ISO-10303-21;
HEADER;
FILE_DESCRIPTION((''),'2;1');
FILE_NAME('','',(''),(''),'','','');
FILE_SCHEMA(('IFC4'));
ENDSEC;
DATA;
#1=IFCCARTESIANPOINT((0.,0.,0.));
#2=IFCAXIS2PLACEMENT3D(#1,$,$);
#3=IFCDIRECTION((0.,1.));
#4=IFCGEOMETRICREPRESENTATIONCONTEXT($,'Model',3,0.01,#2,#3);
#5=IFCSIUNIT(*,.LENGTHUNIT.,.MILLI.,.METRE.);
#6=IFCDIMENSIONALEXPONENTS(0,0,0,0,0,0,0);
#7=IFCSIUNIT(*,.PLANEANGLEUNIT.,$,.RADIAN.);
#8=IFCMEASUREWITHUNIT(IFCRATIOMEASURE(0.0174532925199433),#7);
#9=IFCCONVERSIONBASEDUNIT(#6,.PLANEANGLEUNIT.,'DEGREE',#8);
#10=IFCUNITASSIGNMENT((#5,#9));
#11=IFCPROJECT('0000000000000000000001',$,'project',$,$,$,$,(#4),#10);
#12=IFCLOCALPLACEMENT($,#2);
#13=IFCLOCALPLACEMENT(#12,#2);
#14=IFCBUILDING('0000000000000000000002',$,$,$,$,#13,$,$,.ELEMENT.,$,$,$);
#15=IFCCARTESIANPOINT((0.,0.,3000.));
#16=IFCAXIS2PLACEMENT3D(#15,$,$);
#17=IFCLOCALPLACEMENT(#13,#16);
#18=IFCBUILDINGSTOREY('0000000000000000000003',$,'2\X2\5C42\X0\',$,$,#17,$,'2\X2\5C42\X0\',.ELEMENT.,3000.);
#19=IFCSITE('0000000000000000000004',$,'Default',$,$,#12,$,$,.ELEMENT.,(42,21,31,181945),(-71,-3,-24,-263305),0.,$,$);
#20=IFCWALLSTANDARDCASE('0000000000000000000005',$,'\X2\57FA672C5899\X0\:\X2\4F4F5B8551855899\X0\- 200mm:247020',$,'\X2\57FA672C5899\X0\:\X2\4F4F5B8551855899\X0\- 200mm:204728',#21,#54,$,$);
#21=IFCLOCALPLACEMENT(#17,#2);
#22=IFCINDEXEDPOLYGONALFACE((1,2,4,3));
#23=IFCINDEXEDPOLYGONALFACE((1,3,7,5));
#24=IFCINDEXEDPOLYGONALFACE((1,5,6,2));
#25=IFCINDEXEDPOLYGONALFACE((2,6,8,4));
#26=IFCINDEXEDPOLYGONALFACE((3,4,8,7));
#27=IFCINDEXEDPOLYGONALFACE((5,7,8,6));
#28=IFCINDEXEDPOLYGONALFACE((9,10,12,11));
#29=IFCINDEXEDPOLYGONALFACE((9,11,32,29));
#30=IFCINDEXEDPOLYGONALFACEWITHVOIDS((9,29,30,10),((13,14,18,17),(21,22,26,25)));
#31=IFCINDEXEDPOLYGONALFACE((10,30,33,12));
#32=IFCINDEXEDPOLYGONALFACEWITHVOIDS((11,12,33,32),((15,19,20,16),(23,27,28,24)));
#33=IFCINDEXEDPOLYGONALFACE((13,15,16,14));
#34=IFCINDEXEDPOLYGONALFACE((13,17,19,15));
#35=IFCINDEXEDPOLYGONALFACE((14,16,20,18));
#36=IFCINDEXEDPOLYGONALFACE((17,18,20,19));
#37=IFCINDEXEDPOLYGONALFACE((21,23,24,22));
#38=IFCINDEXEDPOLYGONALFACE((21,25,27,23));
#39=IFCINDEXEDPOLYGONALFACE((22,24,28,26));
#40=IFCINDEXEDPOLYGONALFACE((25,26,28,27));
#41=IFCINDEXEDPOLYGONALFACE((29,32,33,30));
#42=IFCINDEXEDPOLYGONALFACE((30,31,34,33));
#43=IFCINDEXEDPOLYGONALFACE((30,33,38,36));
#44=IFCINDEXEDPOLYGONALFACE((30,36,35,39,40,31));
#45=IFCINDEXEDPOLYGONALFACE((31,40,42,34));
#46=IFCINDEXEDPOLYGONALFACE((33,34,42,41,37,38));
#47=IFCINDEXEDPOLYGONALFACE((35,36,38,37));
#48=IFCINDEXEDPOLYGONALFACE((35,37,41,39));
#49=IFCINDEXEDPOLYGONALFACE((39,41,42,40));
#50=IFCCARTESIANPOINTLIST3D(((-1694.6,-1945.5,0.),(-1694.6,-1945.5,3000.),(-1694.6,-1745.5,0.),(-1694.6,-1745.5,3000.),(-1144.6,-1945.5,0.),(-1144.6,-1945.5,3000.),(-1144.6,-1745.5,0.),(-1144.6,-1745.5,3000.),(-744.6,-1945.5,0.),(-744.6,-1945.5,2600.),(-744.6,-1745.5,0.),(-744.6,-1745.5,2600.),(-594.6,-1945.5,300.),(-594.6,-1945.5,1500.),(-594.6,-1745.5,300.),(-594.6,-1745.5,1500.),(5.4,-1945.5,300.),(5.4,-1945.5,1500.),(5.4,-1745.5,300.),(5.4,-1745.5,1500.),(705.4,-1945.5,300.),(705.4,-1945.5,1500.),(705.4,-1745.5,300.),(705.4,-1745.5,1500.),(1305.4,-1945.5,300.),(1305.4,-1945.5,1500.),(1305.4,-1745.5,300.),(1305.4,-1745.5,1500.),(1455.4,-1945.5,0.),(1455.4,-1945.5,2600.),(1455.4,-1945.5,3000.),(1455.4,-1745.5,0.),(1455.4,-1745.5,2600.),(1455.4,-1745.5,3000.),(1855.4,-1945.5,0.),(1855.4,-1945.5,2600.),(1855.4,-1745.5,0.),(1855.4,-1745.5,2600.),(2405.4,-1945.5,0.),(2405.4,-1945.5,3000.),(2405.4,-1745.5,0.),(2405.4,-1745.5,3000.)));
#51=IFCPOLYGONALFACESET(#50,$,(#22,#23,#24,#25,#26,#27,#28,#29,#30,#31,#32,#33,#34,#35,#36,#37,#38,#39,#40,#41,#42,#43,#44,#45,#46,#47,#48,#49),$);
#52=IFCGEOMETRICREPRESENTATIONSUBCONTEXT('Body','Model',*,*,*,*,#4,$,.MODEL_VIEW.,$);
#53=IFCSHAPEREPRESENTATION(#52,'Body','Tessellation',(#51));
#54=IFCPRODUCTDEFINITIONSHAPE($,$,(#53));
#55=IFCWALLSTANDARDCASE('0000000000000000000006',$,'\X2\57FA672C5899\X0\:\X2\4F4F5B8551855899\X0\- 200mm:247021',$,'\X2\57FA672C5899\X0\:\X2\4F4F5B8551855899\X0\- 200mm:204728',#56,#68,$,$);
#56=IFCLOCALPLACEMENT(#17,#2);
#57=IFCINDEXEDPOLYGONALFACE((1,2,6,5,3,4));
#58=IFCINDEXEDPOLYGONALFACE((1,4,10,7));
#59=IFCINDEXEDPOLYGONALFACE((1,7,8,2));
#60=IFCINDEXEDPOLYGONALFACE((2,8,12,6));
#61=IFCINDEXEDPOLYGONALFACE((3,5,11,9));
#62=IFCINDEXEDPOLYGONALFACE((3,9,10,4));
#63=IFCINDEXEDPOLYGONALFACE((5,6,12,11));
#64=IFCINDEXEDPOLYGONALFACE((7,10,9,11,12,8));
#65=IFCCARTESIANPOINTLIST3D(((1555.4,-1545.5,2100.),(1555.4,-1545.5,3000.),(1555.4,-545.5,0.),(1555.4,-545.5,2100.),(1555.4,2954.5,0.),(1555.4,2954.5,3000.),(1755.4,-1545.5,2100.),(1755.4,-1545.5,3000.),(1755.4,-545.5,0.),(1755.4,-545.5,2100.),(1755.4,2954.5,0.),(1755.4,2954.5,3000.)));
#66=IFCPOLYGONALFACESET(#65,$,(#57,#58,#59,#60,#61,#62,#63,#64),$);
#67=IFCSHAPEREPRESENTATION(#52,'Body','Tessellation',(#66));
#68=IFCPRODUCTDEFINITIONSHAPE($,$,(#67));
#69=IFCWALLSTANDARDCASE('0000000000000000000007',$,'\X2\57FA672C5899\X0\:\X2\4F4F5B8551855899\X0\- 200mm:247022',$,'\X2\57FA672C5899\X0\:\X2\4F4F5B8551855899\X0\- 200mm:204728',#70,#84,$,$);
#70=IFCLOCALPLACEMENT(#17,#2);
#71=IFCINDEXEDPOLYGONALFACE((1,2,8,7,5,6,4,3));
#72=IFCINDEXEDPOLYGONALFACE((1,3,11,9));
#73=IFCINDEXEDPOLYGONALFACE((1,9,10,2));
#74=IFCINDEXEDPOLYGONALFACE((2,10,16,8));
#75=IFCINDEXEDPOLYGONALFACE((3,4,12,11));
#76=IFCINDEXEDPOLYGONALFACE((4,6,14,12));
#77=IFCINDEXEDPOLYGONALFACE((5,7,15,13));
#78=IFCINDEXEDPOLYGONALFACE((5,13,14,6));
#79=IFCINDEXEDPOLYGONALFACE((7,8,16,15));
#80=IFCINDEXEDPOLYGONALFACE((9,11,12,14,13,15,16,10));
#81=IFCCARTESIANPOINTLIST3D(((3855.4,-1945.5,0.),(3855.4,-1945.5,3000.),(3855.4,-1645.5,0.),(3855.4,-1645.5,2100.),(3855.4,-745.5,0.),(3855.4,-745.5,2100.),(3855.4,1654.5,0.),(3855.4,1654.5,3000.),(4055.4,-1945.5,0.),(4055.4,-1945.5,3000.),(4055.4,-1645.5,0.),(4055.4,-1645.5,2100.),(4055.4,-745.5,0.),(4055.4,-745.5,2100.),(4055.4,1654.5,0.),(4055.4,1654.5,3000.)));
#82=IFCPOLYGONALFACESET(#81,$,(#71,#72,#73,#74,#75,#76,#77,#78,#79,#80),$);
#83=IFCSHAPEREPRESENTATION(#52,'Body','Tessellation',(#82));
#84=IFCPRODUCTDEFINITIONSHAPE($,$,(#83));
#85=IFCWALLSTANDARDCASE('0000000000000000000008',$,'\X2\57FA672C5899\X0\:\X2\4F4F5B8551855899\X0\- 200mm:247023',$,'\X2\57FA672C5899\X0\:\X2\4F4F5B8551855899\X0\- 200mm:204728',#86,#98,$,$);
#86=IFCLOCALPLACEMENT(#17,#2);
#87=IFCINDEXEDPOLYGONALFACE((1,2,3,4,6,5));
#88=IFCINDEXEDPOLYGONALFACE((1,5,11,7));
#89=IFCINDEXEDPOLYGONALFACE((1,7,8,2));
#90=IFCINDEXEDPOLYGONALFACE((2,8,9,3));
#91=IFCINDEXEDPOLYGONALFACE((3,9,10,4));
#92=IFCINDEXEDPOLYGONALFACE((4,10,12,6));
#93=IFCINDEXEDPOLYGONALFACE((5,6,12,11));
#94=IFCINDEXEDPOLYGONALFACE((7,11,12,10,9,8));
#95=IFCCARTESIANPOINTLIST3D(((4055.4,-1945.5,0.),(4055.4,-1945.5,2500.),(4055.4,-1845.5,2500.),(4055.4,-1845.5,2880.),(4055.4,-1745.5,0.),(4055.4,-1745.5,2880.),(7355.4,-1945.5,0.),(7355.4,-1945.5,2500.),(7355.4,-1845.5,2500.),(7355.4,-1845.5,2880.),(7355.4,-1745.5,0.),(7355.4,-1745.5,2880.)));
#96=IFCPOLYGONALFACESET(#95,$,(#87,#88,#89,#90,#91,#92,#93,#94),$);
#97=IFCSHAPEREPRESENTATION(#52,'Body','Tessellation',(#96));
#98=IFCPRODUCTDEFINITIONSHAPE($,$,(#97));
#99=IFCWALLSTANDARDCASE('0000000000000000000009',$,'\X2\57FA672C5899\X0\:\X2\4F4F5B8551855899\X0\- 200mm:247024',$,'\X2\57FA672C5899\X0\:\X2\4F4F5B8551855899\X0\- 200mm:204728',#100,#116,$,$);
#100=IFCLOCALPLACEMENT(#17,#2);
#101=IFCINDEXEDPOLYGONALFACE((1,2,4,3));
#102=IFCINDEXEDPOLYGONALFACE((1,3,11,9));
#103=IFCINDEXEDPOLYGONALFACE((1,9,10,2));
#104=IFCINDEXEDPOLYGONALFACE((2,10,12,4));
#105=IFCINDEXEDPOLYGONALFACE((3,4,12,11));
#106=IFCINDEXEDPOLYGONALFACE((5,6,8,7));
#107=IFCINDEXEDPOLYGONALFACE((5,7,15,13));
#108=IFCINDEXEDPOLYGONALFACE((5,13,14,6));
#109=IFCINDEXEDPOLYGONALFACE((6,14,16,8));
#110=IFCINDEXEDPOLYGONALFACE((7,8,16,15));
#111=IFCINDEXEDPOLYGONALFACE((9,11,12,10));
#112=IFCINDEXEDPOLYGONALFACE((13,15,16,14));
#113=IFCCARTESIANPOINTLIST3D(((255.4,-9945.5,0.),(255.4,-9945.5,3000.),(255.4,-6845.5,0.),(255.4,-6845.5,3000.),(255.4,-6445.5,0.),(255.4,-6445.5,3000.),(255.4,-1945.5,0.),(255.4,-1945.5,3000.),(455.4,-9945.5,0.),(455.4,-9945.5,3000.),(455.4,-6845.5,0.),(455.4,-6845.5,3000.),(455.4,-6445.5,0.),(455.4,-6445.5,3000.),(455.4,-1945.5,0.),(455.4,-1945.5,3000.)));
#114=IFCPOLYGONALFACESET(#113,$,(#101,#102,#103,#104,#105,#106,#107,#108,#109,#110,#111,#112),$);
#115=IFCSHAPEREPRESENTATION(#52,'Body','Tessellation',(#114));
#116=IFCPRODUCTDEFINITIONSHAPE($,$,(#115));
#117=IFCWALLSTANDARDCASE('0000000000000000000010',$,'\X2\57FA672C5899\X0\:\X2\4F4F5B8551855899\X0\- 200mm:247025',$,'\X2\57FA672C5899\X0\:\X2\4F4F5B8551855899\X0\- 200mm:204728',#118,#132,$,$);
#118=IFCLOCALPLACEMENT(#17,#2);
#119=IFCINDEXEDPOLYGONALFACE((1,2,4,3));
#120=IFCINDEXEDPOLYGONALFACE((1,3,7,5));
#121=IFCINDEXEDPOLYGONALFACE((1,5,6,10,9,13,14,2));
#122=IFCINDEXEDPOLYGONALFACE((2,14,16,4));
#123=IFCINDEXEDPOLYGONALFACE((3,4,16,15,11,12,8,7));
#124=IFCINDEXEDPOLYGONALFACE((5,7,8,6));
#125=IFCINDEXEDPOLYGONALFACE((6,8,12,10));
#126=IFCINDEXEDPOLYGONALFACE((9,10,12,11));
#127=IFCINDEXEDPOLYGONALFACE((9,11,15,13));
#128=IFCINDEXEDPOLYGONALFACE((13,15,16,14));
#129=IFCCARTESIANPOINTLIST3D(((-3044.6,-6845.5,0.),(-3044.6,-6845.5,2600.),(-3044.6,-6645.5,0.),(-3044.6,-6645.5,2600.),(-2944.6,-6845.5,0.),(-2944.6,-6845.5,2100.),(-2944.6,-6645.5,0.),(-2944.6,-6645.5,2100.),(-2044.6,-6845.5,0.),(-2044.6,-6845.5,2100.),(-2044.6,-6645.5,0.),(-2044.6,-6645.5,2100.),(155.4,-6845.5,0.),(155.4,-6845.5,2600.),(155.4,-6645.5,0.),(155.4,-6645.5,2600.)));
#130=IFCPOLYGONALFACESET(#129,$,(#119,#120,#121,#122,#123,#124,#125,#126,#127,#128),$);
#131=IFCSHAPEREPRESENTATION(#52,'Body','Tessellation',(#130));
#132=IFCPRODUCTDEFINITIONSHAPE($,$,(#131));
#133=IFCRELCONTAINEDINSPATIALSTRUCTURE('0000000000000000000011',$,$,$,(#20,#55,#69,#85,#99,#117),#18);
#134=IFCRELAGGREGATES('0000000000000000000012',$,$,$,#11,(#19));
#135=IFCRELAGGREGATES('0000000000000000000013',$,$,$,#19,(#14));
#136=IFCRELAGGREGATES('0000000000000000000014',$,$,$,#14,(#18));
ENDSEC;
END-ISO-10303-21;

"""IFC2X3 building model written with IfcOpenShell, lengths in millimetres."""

from ifc_helpers import new_model, entity, si_unit, converted_unit, direction, frame, frame_2d, origin, place, context, subcontext, project, spatial, polyline, rectangle, extrude, clip, bounded_halfspace, element, save


model = new_model("IFC2X3")

# Units and contexts
model_context = context("Model", 3, precision=0.01, world=origin(), true_north=direction((0.0, 1.0)))
body_context = subcontext(model_context, "Body", "Model", "MODEL_VIEW")
ifc_project = project(units=[si_unit("LENGTHUNIT", "METRE", prefix="MILLI"), converted_unit("PLANEANGLEUNIT", "DEGREE", entity("IfcRatioMeasure", 0.0174532925199433), si_unit("PLANEANGLEUNIT", "RADIAN"), dimensions=[0, 0, 0, 0, 0, 0, 0])], contexts=[model_context])

# Site, building, storey
site_placement = place(None, origin())
site = spatial("IfcSite", under=ifc_project, at=site_placement, Name="Default", CompositionType="ELEMENT", RefLatitude=(42, 21, 31, 181945), RefLongitude=(-71, -3, -24, -263305), RefElevation=0.0)
building_placement = place(site_placement, origin())
building = spatial("IfcBuilding", under=site, at=building_placement, CompositionType="ELEMENT")
storey_placement = place(building_placement, frame((0.0, 0.0, 3000.0)))
storey = spatial("IfcBuildingStorey", under=building, at=storey_placement, Name="2层", LongName="2层", CompositionType="ELEMENT", Elevation=3000.0)

# Wall, openings
wall_1_placement = place(storey_placement, frame((-1694.6, -1845.5, 0.0)))
wall_1 = element("IfcWallStandardCase", 1, at=wall_1_placement, inside=storey, Name="基本墙:住宅内墙- 200mm:247020", ObjectType="基本墙:住宅内墙- 200mm:204728", context=body_context, shape_type="Clipping", body=[
    clip(extrude(rectangle(XDim=4100.0, YDim=200.0, at=frame_2d((2050.0, 0.0), x_axis=(-1.0, 0.0))), origin(), (0.0, 0.0, 1.0), 3000.0), bounded_halfspace(frame((950.0, -100.0, 2600.0), z_axis=(0.0, 0.0, -1.0), x_axis=(-1.0, 0.0, 0.0)), True, frame((950.0, -100.0, 2600.0), z_axis=(0.0, 0.0, -1.0), x_axis=(-1.0, 0.0, 0.0)), polyline([(0.0, 0.0), (0.0, 200.0), (-2200.0, 200.0), (-2200.0, 0.0), (0.0, 0.0)]))),
])
opening_1_placement = place(wall_1_placement, frame((3000.0, 100.0, 300.0)))
element("IfcOpeningElement", 2, at=opening_1_placement, cuts=wall_1, ObjectType="Opening", context=body_context, shape_type="SweptSolid", body=[
    extrude(rectangle(XDim=1200.0, YDim=600.0, at=frame_2d((600.0, 300.0), x_axis=(-1.0, 0.0))), frame((0.0, 0.0, 0.0), z_axis=(0.0, -1.0, 0.0), x_axis=(0.0, 0.0, 1.0)), (0.0, 0.0, 1.0), 200.0),
])
opening_2_placement = place(wall_1_placement, frame((1700.0, 100.0, 300.0)))
element("IfcOpeningElement", 3, at=opening_2_placement, cuts=wall_1, ObjectType="Opening", context=body_context, shape_type="SweptSolid", body=[
    extrude(rectangle(XDim=1200.0, YDim=600.0, at=frame_2d((600.0, 300.0), x_axis=(-1.0, 0.0))), frame((0.0, 0.0, 0.0), z_axis=(0.0, -1.0, 0.0), x_axis=(0.0, 0.0, 1.0)), (0.0, 0.0, 1.0), 200.0),
])
opening_3_placement = place(storey_placement, frame((-1694.6, -1845.5, 0.0)))
element("IfcOpeningElement", 4, at=opening_3_placement, cuts=wall_1, ObjectType="Opening", context=body_context, shape_type="SweptSolid", body=[
    extrude(rectangle(XDim=2600.0, YDim=200.0, at=frame_2d((0.0, 0.0), x_axis=(0.0, 1.0))), frame((3150.0, 0.0, 1300.0), z_axis=(1.0, 0.0, 0.0), x_axis=(0.0, 1.0, 0.0)), (0.0, 0.0, 1.0), 400.0),
])
opening_4_placement = place(storey_placement, frame((-1694.6, -1845.5, 0.0)))
element("IfcOpeningElement", 5, at=opening_4_placement, cuts=wall_1, ObjectType="Opening", context=body_context, shape_type="SweptSolid", body=[
    extrude(rectangle(XDim=3000.0, YDim=200.0, at=frame_2d((0.0, 0.0), x_axis=(1.0, 0.0))), frame((550.0, 0.0, 1500.0), z_axis=(1.0, 0.0, 0.0), x_axis=(0.0, 0.0, -1.0)), (0.0, 0.0, 1.0), 400.0),
])

# Walls, openings
wall_2_placement = place(storey_placement, frame((1655.4, -1545.5, 0.0), z_axis=(0.0, 0.0, 1.0), x_axis=(0.0, 1.0, 0.0)))
wall_2 = element("IfcWallStandardCase", 6, at=wall_2_placement, inside=storey, Name="基本墙:住宅内墙- 200mm:247021", ObjectType="基本墙:住宅内墙- 200mm:204728", context=body_context, shape_type="Clipping", body=[
    clip(clip(extrude(rectangle(XDim=4500.0, YDim=200.0, at=frame_2d((2250.0, 0.0), x_axis=(-1.0, 0.0))), origin(), (0.0, 0.0, 1.0), 3000.0), bounded_halfspace(frame((0.0, -100.0, 2100.0), z_axis=(-1.0, 0.0, 0.0), x_axis=(0.0, 0.0, -1.0)), False, frame((0.0, -100.0, 2100.0), z_axis=(-1.0, 0.0, 0.0), x_axis=(0.0, 0.0, -1.0)), polyline([(0.0, 0.0), (-900.0, 0.0), (-900.0, -200.0), (0.0, -200.0), (0.0, 0.0)]))), bounded_halfspace(frame((4500.0, -100.0, 3000.0), z_axis=(1.0, 0.0, 0.0), x_axis=(0.0, 0.0, -1.0)), False, frame((4500.0, -100.0, 3000.0), z_axis=(1.0, 0.0, 0.0), x_axis=(0.0, 0.0, -1.0)), polyline([(0.0, 0.0), (3000.0, 0.0), (3000.0, 200.0), (0.0, 200.0), (0.0, 0.0)]))),
])
opening_5_placement = place(wall_2_placement, frame((0.0, -100.0, 0.0)))
element("IfcOpeningElement", 7, at=opening_5_placement, cuts=wall_2, ObjectType="Opening", context=body_context, shape_type="SweptSolid", body=[
    extrude(rectangle(XDim=2100.0, YDim=1000.0, at=frame_2d((1050.0, 500.0), x_axis=(1.0, 0.0))), frame((0.0, 0.0, 0.0), z_axis=(0.0, 1.0, 0.0), x_axis=(0.0, 0.0, 1.0)), (0.0, 0.0, 1.0), 200.0),
])
wall_3_placement = place(storey_placement, frame((3955.4, 1654.5, 0.0), z_axis=(0.0, 0.0, 1.0), x_axis=(0.0, -1.0, 0.0)))
wall_3 = element("IfcWallStandardCase", 8, at=wall_3_placement, inside=storey, Name="基本墙:住宅内墙- 200mm:247022", ObjectType="基本墙:住宅内墙- 200mm:204728", context=body_context, shape_type="SweptSolid", body=[
    extrude(rectangle(XDim=3600.0, YDim=200.0, at=frame_2d((1800.0, 0.0), x_axis=(-1.0, 0.0))), origin(), (0.0, 0.0, 1.0), 3000.0),
])
opening_6_placement = place(wall_3_placement, frame((2400.0, -100.0, 0.0)))
element("IfcOpeningElement", 9, at=opening_6_placement, cuts=wall_3, ObjectType="Opening", context=body_context, shape_type="SweptSolid", body=[
    extrude(rectangle(XDim=2100.0, YDim=900.0, at=frame_2d((1050.0, 450.0), x_axis=(1.0, 0.0))), frame((0.0, 0.0, 0.0), z_axis=(0.0, 1.0, 0.0), x_axis=(0.0, 0.0, 1.0)), (0.0, 0.0, 1.0), 200.0),
])

# Wall
wall_4_placement = place(storey_placement, frame((4055.4, -1845.5, 0.0)))
element("IfcWallStandardCase", 10, at=wall_4_placement, inside=storey, Name="基本墙:住宅内墙- 200mm:247023", ObjectType="基本墙:住宅内墙- 200mm:204728", context=body_context, shape_type="Clipping", body=[
    clip(clip(clip(clip(extrude(rectangle(XDim=3300.0, YDim=200.0, at=frame_2d((1650.0, 0.0), x_axis=(-1.0, 0.0))), origin(), (0.0, 0.0, 1.0), 2880.0), bounded_halfspace(frame((3300.0, -100.0, 0.0), z_axis=(1.0, 0.0, 0.0), x_axis=(0.0, 0.0, -1.0)), False, frame((3300.0, -100.0, 0.0), z_axis=(1.0, 0.0, 0.0), x_axis=(0.0, 0.0, -1.0)), polyline([(0.0, 0.0), (0.0, 200.0), (-2880.0, 200.0), (-2880.0, 100.0), (-2500.0, 100.0), (-2500.0, 0.0), (0.0, 0.0)]))), bounded_halfspace(frame((3300.0, 100.0, 2880.0), z_axis=(0.0, 0.0, -1.0), x_axis=(1.0, 0.0, 0.0)), True, frame((3300.0, 100.0, 2880.0), z_axis=(0.0, 0.0, -1.0), x_axis=(1.0, 0.0, 0.0)), polyline([(0.0, 0.0), (0.0, 100.0), (-3300.0, 100.0), (-3300.0, 0.0), (0.0, 0.0)]))), bounded_halfspace(frame((3300.0, 0.0, 2500.0)), False, frame((3300.0, 0.0, 2500.0)), polyline([(0.0, 0.0), (-3300.0, 0.0), (-3300.0, -100.0), (0.0, -100.0), (0.0, 0.0)]))), bounded_halfspace(frame((0.0, 0.0, 2500.0), z_axis=(0.0, -1.0, 0.0), x_axis=(1.0, 0.0, 0.0)), False, frame((0.0, 0.0, 2500.0), z_axis=(0.0, -1.0, 0.0), x_axis=(1.0, 0.0, 0.0)), polyline([(0.0, 0.0), (3300.0, 0.0), (3300.0, 380.0), (0.0, 380.0), (0.0, 0.0)]))),
])

# Walls, openings
wall_5_placement = place(storey_placement, frame((355.4, -1945.5, 0.0), z_axis=(0.0, 0.0, 1.0), x_axis=(0.0, -1.0, 0.0)))
wall_5 = element("IfcWallStandardCase", 11, at=wall_5_placement, inside=storey, Name="基本墙:住宅内墙- 200mm:247024", ObjectType="基本墙:住宅内墙- 200mm:204728", context=body_context, shape_type="Clipping", body=[
    clip(extrude(rectangle(XDim=8000.0, YDim=200.0, at=frame_2d((4000.0, 0.0), x_axis=(-1.0, 0.0))), origin(), (0.0, 0.0, 1.0), 3000.0), bounded_halfspace(frame((8000.0, -100.0, 3000.0), z_axis=(-1.0, 0.0, 0.0), x_axis=(0.0, 0.0, -1.0)), True, frame((8000.0, -100.0, 3000.0), z_axis=(-1.0, 0.0, 0.0), x_axis=(0.0, 0.0, -1.0)), polyline([(0.0, 0.0), (0.0, -200.0), (3000.0, -200.0), (3000.0, 0.0), (0.0, 0.0)]))),
])
opening_7_placement = place(storey_placement, frame((355.4, -1945.5, 0.0), z_axis=(0.0, 0.0, 1.0), x_axis=(0.0, -1.0, 0.0)))
element("IfcOpeningElement", 12, at=opening_7_placement, cuts=wall_5, ObjectType="Opening", context=body_context, shape_type="SweptSolid", body=[
    extrude(rectangle(XDim=3000.0, YDim=200.0, at=frame_2d((0.0, 0.0), x_axis=(1.0, 0.0))), frame((4900.0, 0.0, 1500.0), z_axis=(-1.0, 0.0, 0.0), x_axis=(0.0, 0.0, 1.0)), (0.0, 0.0, 1.0), 400.0),
])
wall_6_placement = place(storey_placement, frame((-3044.6, -6745.5, 0.0)))
wall_6 = element("IfcWallStandardCase", 13, at=wall_6_placement, inside=storey, Name="基本墙:住宅内墙- 200mm:247025", ObjectType="基本墙:住宅内墙- 200mm:204728", context=body_context, shape_type="Clipping", body=[
    clip(clip(clip(extrude(rectangle(XDim=3200.0, YDim=200.0, at=frame_2d((1600.0, 0.0), x_axis=(-1.0, 0.0))), origin(), (0.0, 0.0, 1.0), 2600.0), bounded_halfspace(frame((0.0, 100.0, 0.0), z_axis=(1.0, 0.0, 0.0), x_axis=(0.0, 0.0, -1.0)), True, frame((0.0, 100.0, 0.0), z_axis=(1.0, 0.0, 0.0), x_axis=(0.0, 0.0, -1.0)), polyline([(0.0, 0.0), (-2600.0, 0.0), (-2600.0, -200.0), (0.0, -200.0), (0.0, 0.0)]))), bounded_halfspace(frame((3200.0, -100.0, 0.0), z_axis=(-1.0, 0.0, 0.0), x_axis=(0.0, 0.0, -1.0)), True, frame((3200.0, -100.0, 0.0), z_axis=(-1.0, 0.0, 0.0), x_axis=(0.0, 0.0, -1.0)), polyline([(0.0, 0.0), (-2600.0, 0.0), (-2600.0, -200.0), (0.0, -200.0), (0.0, 0.0)]))), bounded_halfspace(frame((0.0, -100.0, 2600.0), z_axis=(0.0, 0.0, 1.0), x_axis=(0.0, 1.0, 0.0)), False, frame((0.0, -100.0, 2600.0), z_axis=(0.0, 0.0, 1.0), x_axis=(0.0, 1.0, 0.0)), polyline([(0.0, 0.0), (0.0, -3200.0), (200.0, -3200.0), (200.0, 0.0), (0.0, 0.0)]))),
])
opening_8_placement = place(wall_6_placement, frame((1000.0, 100.0, 0.0)))
element("IfcOpeningElement", 14, at=opening_8_placement, cuts=wall_6, ObjectType="Opening", context=body_context, shape_type="SweptSolid", body=[
    extrude(rectangle(XDim=2100.0, YDim=900.0, at=frame_2d((1050.0, 450.0), x_axis=(1.0, 0.0))), frame((0.0, 0.0, 0.0), z_axis=(0.0, -1.0, 0.0), x_axis=(0.0, 0.0, 1.0)), (0.0, 0.0, 1.0), 200.0),
])

save(model, "model.ifc")
